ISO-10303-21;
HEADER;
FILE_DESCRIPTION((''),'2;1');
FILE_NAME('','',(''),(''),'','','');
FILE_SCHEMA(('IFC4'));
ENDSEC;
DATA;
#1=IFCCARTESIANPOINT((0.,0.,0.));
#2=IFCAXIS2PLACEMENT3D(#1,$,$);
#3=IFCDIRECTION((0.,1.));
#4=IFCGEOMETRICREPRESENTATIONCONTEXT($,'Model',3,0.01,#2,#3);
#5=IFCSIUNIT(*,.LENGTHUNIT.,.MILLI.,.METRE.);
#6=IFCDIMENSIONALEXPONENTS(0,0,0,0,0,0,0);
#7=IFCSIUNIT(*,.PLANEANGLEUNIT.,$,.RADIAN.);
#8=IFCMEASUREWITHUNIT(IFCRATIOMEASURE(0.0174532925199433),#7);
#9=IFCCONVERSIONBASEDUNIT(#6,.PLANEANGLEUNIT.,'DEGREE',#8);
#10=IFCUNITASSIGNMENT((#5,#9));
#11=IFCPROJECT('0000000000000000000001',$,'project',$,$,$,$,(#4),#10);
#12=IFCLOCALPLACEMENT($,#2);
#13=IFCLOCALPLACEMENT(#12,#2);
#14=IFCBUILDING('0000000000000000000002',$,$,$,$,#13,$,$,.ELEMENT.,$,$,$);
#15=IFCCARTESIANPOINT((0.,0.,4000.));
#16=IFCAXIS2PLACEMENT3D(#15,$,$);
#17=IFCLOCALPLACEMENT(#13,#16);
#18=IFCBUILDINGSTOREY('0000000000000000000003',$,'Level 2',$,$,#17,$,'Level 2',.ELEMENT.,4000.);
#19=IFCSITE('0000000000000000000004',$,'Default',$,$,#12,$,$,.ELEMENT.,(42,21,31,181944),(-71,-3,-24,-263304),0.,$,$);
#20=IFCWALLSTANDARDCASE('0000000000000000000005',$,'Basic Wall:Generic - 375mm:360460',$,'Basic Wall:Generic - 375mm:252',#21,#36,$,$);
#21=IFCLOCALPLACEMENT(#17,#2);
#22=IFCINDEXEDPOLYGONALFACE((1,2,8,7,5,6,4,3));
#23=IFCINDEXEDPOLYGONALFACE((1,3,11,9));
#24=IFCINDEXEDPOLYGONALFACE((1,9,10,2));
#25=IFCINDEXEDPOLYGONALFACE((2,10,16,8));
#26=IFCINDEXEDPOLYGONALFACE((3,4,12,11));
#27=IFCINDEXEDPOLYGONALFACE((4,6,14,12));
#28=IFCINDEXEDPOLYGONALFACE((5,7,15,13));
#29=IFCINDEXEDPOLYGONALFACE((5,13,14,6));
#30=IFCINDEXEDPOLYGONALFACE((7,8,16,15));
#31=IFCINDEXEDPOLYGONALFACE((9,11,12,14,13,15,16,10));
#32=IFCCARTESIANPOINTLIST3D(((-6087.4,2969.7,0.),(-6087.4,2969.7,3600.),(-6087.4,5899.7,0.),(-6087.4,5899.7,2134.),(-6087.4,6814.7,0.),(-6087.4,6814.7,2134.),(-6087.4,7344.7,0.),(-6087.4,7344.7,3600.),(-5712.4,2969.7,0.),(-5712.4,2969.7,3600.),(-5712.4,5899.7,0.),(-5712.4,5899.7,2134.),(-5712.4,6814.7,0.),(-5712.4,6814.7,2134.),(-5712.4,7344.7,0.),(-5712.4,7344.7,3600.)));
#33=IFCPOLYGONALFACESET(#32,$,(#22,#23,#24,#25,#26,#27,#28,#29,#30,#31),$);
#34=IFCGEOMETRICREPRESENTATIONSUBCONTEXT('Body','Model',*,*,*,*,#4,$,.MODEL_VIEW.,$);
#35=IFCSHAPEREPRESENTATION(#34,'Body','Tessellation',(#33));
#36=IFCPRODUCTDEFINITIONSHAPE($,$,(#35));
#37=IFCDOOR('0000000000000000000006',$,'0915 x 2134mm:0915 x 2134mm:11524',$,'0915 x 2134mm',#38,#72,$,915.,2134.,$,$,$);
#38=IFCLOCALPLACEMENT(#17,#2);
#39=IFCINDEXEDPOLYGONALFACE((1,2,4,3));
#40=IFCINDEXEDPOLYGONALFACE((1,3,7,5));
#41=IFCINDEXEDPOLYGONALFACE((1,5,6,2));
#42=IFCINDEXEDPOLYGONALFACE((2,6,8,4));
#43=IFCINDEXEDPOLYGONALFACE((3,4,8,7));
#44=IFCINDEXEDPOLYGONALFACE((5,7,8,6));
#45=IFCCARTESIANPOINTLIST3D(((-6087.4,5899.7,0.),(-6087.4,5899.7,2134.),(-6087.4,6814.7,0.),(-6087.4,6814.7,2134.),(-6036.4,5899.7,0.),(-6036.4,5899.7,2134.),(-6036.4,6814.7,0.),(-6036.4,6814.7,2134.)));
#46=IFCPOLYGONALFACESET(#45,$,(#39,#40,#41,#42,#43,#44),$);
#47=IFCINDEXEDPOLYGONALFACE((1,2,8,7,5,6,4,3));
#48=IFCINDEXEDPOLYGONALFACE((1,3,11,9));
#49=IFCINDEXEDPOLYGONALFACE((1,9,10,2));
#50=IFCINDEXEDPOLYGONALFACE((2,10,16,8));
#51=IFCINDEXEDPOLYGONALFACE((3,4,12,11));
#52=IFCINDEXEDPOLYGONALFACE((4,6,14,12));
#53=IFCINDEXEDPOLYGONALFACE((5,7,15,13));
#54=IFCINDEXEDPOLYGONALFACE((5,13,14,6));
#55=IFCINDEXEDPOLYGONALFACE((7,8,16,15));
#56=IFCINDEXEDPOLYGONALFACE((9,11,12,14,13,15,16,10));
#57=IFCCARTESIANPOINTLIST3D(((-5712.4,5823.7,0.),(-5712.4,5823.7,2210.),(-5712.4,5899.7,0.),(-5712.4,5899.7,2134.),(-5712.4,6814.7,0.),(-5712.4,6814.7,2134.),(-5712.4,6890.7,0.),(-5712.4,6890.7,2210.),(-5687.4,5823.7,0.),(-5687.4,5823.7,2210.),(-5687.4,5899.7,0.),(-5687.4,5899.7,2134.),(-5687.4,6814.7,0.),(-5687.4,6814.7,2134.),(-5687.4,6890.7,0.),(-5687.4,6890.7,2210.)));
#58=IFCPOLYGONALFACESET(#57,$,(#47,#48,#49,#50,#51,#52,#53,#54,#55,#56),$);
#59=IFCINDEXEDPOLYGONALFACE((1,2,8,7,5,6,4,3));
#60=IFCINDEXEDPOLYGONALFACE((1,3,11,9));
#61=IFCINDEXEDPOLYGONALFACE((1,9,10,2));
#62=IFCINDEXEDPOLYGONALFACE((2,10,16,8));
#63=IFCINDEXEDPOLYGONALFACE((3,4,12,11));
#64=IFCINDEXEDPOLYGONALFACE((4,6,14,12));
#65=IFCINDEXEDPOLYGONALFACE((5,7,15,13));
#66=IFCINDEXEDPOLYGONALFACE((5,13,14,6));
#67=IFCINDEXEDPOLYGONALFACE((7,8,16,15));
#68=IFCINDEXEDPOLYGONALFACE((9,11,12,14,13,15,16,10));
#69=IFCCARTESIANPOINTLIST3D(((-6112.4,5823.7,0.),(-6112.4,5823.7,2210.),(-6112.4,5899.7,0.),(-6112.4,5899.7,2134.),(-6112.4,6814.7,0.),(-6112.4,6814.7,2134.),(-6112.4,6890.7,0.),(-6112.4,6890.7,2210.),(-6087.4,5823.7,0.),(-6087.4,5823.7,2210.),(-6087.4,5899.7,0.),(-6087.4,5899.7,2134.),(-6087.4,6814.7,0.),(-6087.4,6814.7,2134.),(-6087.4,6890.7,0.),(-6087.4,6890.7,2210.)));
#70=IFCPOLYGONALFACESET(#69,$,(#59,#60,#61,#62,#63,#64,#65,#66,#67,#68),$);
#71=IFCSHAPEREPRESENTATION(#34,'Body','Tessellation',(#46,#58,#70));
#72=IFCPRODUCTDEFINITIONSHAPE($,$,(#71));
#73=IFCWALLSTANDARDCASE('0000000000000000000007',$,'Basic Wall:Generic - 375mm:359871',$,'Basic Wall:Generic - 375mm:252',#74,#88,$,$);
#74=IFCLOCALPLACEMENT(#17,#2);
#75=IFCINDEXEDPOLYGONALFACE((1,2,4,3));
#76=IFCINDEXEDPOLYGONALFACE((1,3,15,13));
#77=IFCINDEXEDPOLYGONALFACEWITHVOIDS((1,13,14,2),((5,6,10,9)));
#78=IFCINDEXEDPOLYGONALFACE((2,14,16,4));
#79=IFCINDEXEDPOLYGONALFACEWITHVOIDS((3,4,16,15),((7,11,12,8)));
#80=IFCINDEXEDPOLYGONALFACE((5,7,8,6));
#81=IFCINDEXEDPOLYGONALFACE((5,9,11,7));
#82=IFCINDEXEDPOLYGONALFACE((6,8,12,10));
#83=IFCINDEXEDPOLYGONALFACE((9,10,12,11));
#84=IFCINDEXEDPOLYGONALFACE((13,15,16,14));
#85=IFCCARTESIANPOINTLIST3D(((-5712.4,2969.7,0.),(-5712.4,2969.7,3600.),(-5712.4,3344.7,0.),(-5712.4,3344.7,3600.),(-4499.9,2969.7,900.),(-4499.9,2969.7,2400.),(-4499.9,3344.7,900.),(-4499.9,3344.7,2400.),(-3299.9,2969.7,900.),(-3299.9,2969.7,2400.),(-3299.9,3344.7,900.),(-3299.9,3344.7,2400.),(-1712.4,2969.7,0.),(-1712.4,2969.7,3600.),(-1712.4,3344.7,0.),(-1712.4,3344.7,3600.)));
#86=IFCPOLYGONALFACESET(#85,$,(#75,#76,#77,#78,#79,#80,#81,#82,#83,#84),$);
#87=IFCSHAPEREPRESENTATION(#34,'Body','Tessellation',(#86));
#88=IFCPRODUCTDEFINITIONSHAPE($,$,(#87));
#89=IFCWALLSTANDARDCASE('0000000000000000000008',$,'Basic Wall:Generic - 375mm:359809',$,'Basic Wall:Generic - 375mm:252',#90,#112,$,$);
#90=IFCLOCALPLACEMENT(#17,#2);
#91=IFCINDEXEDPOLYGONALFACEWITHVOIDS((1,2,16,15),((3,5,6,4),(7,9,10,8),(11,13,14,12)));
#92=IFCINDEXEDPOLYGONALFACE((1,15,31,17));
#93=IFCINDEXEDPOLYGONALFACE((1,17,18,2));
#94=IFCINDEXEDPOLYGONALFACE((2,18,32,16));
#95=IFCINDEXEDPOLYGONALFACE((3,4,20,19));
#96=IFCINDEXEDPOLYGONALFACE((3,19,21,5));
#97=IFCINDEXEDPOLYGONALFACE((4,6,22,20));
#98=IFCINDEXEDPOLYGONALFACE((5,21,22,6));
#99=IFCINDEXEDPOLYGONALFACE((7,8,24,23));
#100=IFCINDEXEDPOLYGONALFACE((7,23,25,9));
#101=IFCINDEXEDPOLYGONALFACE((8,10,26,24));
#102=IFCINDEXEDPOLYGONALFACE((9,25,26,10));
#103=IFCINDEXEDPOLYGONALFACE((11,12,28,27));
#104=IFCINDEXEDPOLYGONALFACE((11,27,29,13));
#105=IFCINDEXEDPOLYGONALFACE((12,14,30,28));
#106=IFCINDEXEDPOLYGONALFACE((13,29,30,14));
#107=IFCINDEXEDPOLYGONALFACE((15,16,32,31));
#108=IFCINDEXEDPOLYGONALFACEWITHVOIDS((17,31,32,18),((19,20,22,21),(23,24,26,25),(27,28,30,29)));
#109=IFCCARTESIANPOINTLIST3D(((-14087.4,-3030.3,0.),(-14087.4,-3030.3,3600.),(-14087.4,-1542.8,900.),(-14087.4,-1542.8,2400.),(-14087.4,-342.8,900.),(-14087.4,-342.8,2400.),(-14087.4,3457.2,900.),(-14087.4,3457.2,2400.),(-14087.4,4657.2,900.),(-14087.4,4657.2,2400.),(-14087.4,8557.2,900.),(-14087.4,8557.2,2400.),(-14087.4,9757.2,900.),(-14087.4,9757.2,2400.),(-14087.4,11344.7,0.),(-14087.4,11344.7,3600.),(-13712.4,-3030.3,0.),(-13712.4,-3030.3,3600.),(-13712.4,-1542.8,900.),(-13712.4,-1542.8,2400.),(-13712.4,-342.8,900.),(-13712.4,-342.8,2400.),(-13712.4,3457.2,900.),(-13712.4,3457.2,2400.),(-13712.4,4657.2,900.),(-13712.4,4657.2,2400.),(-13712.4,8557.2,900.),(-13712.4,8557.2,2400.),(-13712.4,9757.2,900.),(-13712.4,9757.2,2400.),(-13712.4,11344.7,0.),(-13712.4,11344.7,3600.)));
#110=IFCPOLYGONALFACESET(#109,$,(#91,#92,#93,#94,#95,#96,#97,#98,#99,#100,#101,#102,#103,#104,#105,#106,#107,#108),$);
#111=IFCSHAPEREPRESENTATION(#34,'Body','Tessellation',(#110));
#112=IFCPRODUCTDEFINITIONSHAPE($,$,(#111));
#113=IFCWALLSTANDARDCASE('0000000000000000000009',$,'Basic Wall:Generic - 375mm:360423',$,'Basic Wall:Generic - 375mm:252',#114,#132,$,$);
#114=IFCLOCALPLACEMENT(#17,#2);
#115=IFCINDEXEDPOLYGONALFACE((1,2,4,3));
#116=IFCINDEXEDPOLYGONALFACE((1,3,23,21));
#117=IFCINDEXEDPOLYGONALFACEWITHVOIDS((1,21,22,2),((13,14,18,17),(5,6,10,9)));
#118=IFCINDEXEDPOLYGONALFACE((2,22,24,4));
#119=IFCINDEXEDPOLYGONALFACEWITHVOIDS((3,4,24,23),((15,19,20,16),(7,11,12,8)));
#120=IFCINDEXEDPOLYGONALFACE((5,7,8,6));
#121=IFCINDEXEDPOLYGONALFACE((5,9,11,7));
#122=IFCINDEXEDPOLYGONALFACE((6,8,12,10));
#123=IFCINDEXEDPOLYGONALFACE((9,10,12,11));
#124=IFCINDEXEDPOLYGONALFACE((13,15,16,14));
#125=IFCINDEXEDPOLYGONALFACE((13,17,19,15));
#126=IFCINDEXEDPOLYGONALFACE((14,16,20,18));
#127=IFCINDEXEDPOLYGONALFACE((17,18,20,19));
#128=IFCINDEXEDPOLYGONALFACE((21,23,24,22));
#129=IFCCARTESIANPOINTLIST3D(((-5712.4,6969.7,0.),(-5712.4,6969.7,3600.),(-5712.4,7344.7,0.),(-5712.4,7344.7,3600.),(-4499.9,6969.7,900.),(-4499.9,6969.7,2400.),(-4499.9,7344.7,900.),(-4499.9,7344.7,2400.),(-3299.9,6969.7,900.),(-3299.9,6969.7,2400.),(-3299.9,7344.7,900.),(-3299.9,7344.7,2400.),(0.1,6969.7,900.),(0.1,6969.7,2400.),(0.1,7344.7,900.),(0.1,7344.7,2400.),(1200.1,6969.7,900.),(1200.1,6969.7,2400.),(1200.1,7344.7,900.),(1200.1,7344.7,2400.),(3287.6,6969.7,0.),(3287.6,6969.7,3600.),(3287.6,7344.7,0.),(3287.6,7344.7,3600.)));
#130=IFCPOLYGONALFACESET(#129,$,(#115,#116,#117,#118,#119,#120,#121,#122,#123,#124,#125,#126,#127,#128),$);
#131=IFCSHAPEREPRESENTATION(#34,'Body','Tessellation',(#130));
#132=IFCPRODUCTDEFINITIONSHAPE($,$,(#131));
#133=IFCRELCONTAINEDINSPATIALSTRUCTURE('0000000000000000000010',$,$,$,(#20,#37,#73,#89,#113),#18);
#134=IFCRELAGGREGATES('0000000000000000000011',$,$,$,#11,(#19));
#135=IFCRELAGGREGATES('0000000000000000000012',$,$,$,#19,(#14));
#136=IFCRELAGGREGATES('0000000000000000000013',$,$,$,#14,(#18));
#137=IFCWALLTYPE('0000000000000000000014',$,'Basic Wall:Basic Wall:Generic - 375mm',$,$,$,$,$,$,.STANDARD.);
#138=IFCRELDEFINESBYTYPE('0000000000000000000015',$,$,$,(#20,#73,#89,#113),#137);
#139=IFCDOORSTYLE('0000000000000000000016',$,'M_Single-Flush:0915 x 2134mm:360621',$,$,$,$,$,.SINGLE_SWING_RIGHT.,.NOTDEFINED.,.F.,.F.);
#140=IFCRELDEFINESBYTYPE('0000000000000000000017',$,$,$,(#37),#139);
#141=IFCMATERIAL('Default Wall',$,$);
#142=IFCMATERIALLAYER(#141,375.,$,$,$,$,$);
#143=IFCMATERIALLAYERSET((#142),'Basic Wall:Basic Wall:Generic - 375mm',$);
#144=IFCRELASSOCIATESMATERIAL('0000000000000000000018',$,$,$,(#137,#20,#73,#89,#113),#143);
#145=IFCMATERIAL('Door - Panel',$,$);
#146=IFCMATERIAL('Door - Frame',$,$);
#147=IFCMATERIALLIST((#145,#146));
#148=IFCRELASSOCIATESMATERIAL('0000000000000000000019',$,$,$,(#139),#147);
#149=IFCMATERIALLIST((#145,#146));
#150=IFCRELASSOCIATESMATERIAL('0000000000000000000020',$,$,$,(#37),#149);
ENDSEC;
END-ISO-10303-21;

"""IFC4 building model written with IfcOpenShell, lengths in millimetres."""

from ifc_helpers import new_model, entity, si_unit, converted_unit, direction, frame, frame_2d, origin, origin_2d_with_axis, place, context, subcontext, project, spatial, polyline, rectangle, outline, extrude, source, transform, mapped, material, material_list, layer, layer_set, layer_usage, type_object, type_shapes, element, fill, save


model = new_model("IFC4")

# Units and contexts
model_context = context("Model", 3, precision=0.01, world=origin(), true_north=direction((0.0, 1.0)))
body_context = subcontext(model_context, "Body", "Model", "MODEL_VIEW")
ifc_project = project(units=[si_unit("LENGTHUNIT", "METRE", prefix="MILLI"), converted_unit("PLANEANGLEUNIT", "DEGREE", entity("IfcRatioMeasure", 0.0174532925199433), si_unit("PLANEANGLEUNIT", "RADIAN"), dimensions=[0, 0, 0, 0, 0, 0, 0])], contexts=[model_context])

# Site, building, storey
site_placement = place(None, origin())
site = spatial("IfcSite", under=ifc_project, at=site_placement, Name="Default", CompositionType="ELEMENT", RefLatitude=(42, 21, 31, 181944), RefLongitude=(-71, -3, -24, -263304), RefElevation=0.0)
building_placement = place(site_placement, origin())
building = spatial("IfcBuilding", under=site, at=building_placement, CompositionType="ELEMENT")
storey_placement = place(building_placement, frame((0.0, 0.0, 4000.0)))
storey = spatial("IfcBuildingStorey", under=building, at=storey_placement, Name="Level 2", LongName="Level 2", CompositionType="ELEMENT", Elevation=4000.0)

# Wall, opening, door
ifc_material_1 = material(Name="Default Wall")
ifc_layer_1 = layer(ifc_material_1, 375.0)
ifc_layer_set_1 = layer_set([ifc_layer_1], Name="Basic Wall:Basic Wall:Generic - 375mm")
ifc_layer_usage_1 = layer_usage(ifc_layer_set_1, "AXIS2", "NEGATIVE", 187.5)
wall_type_1 = type_object("IfcWallType", Name="Basic Wall:Basic Wall:Generic - 375mm", PredefinedType="STANDARD", material=ifc_layer_set_1)
wall_1_placement = place(storey_placement, frame((-5899.9, 2969.7, 0.0), z_axis=(0.0, 0.0, 1.0), x_axis=(0.0, 1.0, 0.0)))
wall_1 = element("IfcWallStandardCase", 1, at=wall_1_placement, inside=storey, type_object=wall_type_1, material=ifc_layer_usage_1, Name="Basic Wall:Generic - 375mm:360460", ObjectType="Basic Wall:Generic - 375mm:252", context=body_context, shape_type="SweptSolid", body=[
    extrude(rectangle(XDim=4375.0, YDim=375.0, at=frame_2d((2187.5, 0.0), x_axis=(-1.0, 0.0))), origin(), (0.0, 0.0, 1.0), 3600.0),
])
opening_1_placement = place(wall_1_placement, frame((-2969.7, -5899.9, 0.0), z_axis=(0.0, 0.0, 1.0), x_axis=(0.0, -1.0, 0.0)))
opening_1 = element("IfcOpeningElement", 2, at=opening_1_placement, cuts=wall_1, ObjectType="Opening", context=body_context, shape_type="SweptSolid", body=[
    extrude(rectangle(XDim=2134.0, YDim=915.0, at=origin_2d_with_axis()), frame((-5708.7, 6357.2, 1067.0), z_axis=(-1.0, 0.0, 0.0), x_axis=(0.0, 0.0, -1.0)), (0.0, 0.0, 1.0), 382.5),
])
ifc_material_2 = material(Name="Door - Panel")
ifc_material_3 = material(Name="Door - Frame")
ifc_material_list_1 = material_list([ifc_material_2, ifc_material_3])
ifc_material_list_2 = material_list([ifc_material_2, ifc_material_3])
door_style_1 = type_object("IfcDoorStyle", Name="M_Single-Flush:0915 x 2134mm:360621", ConstructionType="NOTDEFINED", OperationType="SINGLE_SWING_RIGHT", ParameterTakesPrecedence=False, Sizeable=False, material=ifc_material_list_2)
shared_shape_1 = source(origin(), body_context, "Body", "SweptSolid", [
    extrude(rectangle(XDim=915.0, YDim=51.0, at=origin_2d_with_axis()), frame((457.5, -29.3, 0.0), z_axis=(0.0, 0.0, 1.0), x_axis=(-1.0, 0.0, 0.0)), (0.0, 0.0, 1.0), 2134.0),
    extrude(outline(polyline([(-533.5, -1086.0), (-457.5, -1086.0), (-457.5, 1048.0), (457.5, 1048.0), (457.5, -1086.0), (533.5, -1086.0), (533.5, 1124.0), (-533.5, 1124.0), (-533.5, -1086.0)])), frame((457.5, -403.7, 1086.0), z_axis=(0.0, 1.0, 0.0), x_axis=(-1.0, 0.0, 0.0)), (0.0, 0.0, 1.0), 25.0),
    extrude(outline(polyline([(-1124.0, -533.5), (1086.0, -533.5), (1086.0, -457.5), (-1048.0, -457.5), (-1048.0, 457.5), (1086.0, 457.5), (1086.0, 533.5), (-1124.0, 533.5), (-1124.0, -533.5)])), frame((457.5, -3.7, 1086.0), z_axis=(0.0, 1.0, 0.0), x_axis=(0.0, 0.0, -1.0)), (0.0, 0.0, 1.0), 25.0),
])
type_shapes(door_style_1, [shared_shape_1])
door_1_placement = place(opening_1_placement, frame((-6091.2, 5899.7, 0.0), z_axis=(0.0, 0.0, 1.0), x_axis=(0.0, 1.0, 0.0)))
door_1 = element("IfcDoor", 3, at=door_1_placement, inside=storey, type_object=door_style_1, material=ifc_material_list_1, Name="0915 x 2134mm:0915 x 2134mm:11524", ObjectType="0915 x 2134mm", OverallHeight=915.0, OverallWidth=2134.0, context=body_context, shape_type="MappedRepresentation", body=[
    mapped(shared_shape_1, transform((0.0, 0.0, 0.0), scale=1.0)),
])
fill(opening_1, door_1)

# Wall, opening
ifc_layer_usage_2 = layer_usage(ifc_layer_set_1, "AXIS2", "NEGATIVE", 187.5)
wall_2_placement = place(storey_placement, frame((-1712.4, 3157.2, 0.0), z_axis=(0.0, 0.0, 1.0), x_axis=(-1.0, 0.0, 0.0)))
wall_2 = element("IfcWallStandardCase", 4, at=wall_2_placement, inside=storey, type_object=wall_type_1, material=ifc_layer_usage_2, Name="Basic Wall:Generic - 375mm:359871", ObjectType="Basic Wall:Generic - 375mm:252", context=body_context, shape_type="SweptSolid", body=[
    extrude(rectangle(XDim=4000.0, YDim=375.0, at=frame_2d((2000.0, 0.0), x_axis=(-1.0, 0.0))), origin(), (0.0, 0.0, 1.0), 3600.0),
])
opening_2_placement = place(wall_2_placement, frame((-1712.4, 3157.2, 0.0), z_axis=(0.0, 0.0, 1.0), x_axis=(-1.0, 0.0, 0.0)))
element("IfcOpeningElement", 5, at=opening_2_placement, cuts=wall_2, ObjectType="Opening", context=body_context, shape_type="SweptSolid", body=[
    extrude(rectangle(XDim=1500.0, YDim=1200.0, at=frame_2d((0.0, 0.0), x_axis=(0.0, 1.0))), frame((-3899.9, 3348.4, 1650.0), z_axis=(0.0, -1.0, 0.0), x_axis=(1.0, 0.0, 0.0)), (0.0, 0.0, 1.0), 382.5),
])

# Walls, openings
ifc_layer_usage_3 = layer_usage(ifc_layer_set_1, "AXIS2", "NEGATIVE", 187.5)
wall_3_placement = place(storey_placement, frame((-13899.9, 11344.7, 0.0), z_axis=(0.0, 0.0, 1.0), x_axis=(0.0, -1.0, 0.0)))
wall_3 = element("IfcWallStandardCase", 6, at=wall_3_placement, inside=storey, type_object=wall_type_1, material=ifc_layer_usage_3, Name="Basic Wall:Generic - 375mm:359809", ObjectType="Basic Wall:Generic - 375mm:252", context=body_context, shape_type="SweptSolid", body=[
    extrude(rectangle(XDim=14375.0, YDim=375.0, at=frame_2d((7187.5, 0.0), x_axis=(-1.0, 0.0))), origin(), (0.0, 0.0, 1.0), 3600.0),
])
opening_3_placement = place(wall_3_placement, frame((11344.7, 13899.9, 0.0), z_axis=(0.0, 0.0, 1.0), x_axis=(0.0, 1.0, 0.0)))
element("IfcOpeningElement", 7, at=opening_3_placement, cuts=wall_3, ObjectType="Opening", context=body_context, shape_type="SweptSolid", body=[
    extrude(rectangle(XDim=1500.0, YDim=1200.0, at=frame_2d((0.0, 0.0), x_axis=(0.0, 1.0))), frame((-14091.2, 9157.2, 1650.0), z_axis=(1.0, 0.0, 0.0), x_axis=(0.0, 1.0, 0.0)), (0.0, 0.0, 1.0), 382.5),
])
opening_4_placement = place(wall_3_placement, frame((11344.7, 13899.9, 0.0), z_axis=(0.0, 0.0, 1.0), x_axis=(0.0, 1.0, 0.0)))
element("IfcOpeningElement", 8, at=opening_4_placement, cuts=wall_3, ObjectType="Opening", context=body_context, shape_type="SweptSolid", body=[
    extrude(rectangle(XDim=1500.0, YDim=1200.0, at=frame_2d((0.0, 0.0), x_axis=(0.0, 1.0))), frame((-14091.2, 4057.2, 1650.0), z_axis=(1.0, 0.0, 0.0), x_axis=(0.0, 1.0, 0.0)), (0.0, 0.0, 1.0), 382.5),
])
opening_5_placement = place(wall_3_placement, frame((11344.7, 13899.9, 0.0), z_axis=(0.0, 0.0, 1.0), x_axis=(0.0, 1.0, 0.0)))
element("IfcOpeningElement", 9, at=opening_5_placement, cuts=wall_3, ObjectType="Opening", context=body_context, shape_type="SweptSolid", body=[
    extrude(rectangle(XDim=1500.0, YDim=1200.0, at=frame_2d((0.0, 0.0), x_axis=(0.0, 1.0))), frame((-14091.2, -942.8, 1650.0), z_axis=(1.0, 0.0, 0.0), x_axis=(0.0, 1.0, 0.0)), (0.0, 0.0, 1.0), 382.5),
])
ifc_layer_usage_4 = layer_usage(ifc_layer_set_1, "AXIS2", "NEGATIVE", 187.5)
wall_4_placement = place(storey_placement, frame((-5712.4, 7157.2, 0.0)))
wall_4 = element("IfcWallStandardCase", 10, at=wall_4_placement, inside=storey, type_object=wall_type_1, material=ifc_layer_usage_4, Name="Basic Wall:Generic - 375mm:360423", ObjectType="Basic Wall:Generic - 375mm:252", context=body_context, shape_type="SweptSolid", body=[
    extrude(rectangle(XDim=9000.0, YDim=375.0, at=frame_2d((4500.0, 0.0), x_axis=(-1.0, 0.0))), origin(), (0.0, 0.0, 1.0), 3600.0),
])
opening_6_placement = place(wall_4_placement, frame((5712.4, -7157.2, 0.0)))
element("IfcOpeningElement", 11, at=opening_6_placement, cuts=wall_4, ObjectType="Opening", context=body_context, shape_type="SweptSolid", body=[
    extrude(rectangle(XDim=1500.0, YDim=1200.0, at=frame_2d((0.0, 0.0), x_axis=(0.0, 1.0))), frame((-3899.9, 6965.9, 1650.0), z_axis=(0.0, 1.0, 0.0), x_axis=(-1.0, 0.0, 0.0)), (0.0, 0.0, 1.0), 382.5),
])
opening_7_placement = place(wall_4_placement, frame((5712.4, -7157.2, 0.0)))
element("IfcOpeningElement", 12, at=opening_7_placement, cuts=wall_4, ObjectType="Opening", context=body_context, shape_type="SweptSolid", body=[
    extrude(rectangle(XDim=1500.0, YDim=1200.0, at=frame_2d((0.0, 0.0), x_axis=(0.0, 1.0))), frame((600.1, 6965.9, 1650.0), z_axis=(0.0, 1.0, 0.0), x_axis=(-1.0, 0.0, 0.0)), (0.0, 0.0, 1.0), 382.5),
])

save(model, "model.ifc")
